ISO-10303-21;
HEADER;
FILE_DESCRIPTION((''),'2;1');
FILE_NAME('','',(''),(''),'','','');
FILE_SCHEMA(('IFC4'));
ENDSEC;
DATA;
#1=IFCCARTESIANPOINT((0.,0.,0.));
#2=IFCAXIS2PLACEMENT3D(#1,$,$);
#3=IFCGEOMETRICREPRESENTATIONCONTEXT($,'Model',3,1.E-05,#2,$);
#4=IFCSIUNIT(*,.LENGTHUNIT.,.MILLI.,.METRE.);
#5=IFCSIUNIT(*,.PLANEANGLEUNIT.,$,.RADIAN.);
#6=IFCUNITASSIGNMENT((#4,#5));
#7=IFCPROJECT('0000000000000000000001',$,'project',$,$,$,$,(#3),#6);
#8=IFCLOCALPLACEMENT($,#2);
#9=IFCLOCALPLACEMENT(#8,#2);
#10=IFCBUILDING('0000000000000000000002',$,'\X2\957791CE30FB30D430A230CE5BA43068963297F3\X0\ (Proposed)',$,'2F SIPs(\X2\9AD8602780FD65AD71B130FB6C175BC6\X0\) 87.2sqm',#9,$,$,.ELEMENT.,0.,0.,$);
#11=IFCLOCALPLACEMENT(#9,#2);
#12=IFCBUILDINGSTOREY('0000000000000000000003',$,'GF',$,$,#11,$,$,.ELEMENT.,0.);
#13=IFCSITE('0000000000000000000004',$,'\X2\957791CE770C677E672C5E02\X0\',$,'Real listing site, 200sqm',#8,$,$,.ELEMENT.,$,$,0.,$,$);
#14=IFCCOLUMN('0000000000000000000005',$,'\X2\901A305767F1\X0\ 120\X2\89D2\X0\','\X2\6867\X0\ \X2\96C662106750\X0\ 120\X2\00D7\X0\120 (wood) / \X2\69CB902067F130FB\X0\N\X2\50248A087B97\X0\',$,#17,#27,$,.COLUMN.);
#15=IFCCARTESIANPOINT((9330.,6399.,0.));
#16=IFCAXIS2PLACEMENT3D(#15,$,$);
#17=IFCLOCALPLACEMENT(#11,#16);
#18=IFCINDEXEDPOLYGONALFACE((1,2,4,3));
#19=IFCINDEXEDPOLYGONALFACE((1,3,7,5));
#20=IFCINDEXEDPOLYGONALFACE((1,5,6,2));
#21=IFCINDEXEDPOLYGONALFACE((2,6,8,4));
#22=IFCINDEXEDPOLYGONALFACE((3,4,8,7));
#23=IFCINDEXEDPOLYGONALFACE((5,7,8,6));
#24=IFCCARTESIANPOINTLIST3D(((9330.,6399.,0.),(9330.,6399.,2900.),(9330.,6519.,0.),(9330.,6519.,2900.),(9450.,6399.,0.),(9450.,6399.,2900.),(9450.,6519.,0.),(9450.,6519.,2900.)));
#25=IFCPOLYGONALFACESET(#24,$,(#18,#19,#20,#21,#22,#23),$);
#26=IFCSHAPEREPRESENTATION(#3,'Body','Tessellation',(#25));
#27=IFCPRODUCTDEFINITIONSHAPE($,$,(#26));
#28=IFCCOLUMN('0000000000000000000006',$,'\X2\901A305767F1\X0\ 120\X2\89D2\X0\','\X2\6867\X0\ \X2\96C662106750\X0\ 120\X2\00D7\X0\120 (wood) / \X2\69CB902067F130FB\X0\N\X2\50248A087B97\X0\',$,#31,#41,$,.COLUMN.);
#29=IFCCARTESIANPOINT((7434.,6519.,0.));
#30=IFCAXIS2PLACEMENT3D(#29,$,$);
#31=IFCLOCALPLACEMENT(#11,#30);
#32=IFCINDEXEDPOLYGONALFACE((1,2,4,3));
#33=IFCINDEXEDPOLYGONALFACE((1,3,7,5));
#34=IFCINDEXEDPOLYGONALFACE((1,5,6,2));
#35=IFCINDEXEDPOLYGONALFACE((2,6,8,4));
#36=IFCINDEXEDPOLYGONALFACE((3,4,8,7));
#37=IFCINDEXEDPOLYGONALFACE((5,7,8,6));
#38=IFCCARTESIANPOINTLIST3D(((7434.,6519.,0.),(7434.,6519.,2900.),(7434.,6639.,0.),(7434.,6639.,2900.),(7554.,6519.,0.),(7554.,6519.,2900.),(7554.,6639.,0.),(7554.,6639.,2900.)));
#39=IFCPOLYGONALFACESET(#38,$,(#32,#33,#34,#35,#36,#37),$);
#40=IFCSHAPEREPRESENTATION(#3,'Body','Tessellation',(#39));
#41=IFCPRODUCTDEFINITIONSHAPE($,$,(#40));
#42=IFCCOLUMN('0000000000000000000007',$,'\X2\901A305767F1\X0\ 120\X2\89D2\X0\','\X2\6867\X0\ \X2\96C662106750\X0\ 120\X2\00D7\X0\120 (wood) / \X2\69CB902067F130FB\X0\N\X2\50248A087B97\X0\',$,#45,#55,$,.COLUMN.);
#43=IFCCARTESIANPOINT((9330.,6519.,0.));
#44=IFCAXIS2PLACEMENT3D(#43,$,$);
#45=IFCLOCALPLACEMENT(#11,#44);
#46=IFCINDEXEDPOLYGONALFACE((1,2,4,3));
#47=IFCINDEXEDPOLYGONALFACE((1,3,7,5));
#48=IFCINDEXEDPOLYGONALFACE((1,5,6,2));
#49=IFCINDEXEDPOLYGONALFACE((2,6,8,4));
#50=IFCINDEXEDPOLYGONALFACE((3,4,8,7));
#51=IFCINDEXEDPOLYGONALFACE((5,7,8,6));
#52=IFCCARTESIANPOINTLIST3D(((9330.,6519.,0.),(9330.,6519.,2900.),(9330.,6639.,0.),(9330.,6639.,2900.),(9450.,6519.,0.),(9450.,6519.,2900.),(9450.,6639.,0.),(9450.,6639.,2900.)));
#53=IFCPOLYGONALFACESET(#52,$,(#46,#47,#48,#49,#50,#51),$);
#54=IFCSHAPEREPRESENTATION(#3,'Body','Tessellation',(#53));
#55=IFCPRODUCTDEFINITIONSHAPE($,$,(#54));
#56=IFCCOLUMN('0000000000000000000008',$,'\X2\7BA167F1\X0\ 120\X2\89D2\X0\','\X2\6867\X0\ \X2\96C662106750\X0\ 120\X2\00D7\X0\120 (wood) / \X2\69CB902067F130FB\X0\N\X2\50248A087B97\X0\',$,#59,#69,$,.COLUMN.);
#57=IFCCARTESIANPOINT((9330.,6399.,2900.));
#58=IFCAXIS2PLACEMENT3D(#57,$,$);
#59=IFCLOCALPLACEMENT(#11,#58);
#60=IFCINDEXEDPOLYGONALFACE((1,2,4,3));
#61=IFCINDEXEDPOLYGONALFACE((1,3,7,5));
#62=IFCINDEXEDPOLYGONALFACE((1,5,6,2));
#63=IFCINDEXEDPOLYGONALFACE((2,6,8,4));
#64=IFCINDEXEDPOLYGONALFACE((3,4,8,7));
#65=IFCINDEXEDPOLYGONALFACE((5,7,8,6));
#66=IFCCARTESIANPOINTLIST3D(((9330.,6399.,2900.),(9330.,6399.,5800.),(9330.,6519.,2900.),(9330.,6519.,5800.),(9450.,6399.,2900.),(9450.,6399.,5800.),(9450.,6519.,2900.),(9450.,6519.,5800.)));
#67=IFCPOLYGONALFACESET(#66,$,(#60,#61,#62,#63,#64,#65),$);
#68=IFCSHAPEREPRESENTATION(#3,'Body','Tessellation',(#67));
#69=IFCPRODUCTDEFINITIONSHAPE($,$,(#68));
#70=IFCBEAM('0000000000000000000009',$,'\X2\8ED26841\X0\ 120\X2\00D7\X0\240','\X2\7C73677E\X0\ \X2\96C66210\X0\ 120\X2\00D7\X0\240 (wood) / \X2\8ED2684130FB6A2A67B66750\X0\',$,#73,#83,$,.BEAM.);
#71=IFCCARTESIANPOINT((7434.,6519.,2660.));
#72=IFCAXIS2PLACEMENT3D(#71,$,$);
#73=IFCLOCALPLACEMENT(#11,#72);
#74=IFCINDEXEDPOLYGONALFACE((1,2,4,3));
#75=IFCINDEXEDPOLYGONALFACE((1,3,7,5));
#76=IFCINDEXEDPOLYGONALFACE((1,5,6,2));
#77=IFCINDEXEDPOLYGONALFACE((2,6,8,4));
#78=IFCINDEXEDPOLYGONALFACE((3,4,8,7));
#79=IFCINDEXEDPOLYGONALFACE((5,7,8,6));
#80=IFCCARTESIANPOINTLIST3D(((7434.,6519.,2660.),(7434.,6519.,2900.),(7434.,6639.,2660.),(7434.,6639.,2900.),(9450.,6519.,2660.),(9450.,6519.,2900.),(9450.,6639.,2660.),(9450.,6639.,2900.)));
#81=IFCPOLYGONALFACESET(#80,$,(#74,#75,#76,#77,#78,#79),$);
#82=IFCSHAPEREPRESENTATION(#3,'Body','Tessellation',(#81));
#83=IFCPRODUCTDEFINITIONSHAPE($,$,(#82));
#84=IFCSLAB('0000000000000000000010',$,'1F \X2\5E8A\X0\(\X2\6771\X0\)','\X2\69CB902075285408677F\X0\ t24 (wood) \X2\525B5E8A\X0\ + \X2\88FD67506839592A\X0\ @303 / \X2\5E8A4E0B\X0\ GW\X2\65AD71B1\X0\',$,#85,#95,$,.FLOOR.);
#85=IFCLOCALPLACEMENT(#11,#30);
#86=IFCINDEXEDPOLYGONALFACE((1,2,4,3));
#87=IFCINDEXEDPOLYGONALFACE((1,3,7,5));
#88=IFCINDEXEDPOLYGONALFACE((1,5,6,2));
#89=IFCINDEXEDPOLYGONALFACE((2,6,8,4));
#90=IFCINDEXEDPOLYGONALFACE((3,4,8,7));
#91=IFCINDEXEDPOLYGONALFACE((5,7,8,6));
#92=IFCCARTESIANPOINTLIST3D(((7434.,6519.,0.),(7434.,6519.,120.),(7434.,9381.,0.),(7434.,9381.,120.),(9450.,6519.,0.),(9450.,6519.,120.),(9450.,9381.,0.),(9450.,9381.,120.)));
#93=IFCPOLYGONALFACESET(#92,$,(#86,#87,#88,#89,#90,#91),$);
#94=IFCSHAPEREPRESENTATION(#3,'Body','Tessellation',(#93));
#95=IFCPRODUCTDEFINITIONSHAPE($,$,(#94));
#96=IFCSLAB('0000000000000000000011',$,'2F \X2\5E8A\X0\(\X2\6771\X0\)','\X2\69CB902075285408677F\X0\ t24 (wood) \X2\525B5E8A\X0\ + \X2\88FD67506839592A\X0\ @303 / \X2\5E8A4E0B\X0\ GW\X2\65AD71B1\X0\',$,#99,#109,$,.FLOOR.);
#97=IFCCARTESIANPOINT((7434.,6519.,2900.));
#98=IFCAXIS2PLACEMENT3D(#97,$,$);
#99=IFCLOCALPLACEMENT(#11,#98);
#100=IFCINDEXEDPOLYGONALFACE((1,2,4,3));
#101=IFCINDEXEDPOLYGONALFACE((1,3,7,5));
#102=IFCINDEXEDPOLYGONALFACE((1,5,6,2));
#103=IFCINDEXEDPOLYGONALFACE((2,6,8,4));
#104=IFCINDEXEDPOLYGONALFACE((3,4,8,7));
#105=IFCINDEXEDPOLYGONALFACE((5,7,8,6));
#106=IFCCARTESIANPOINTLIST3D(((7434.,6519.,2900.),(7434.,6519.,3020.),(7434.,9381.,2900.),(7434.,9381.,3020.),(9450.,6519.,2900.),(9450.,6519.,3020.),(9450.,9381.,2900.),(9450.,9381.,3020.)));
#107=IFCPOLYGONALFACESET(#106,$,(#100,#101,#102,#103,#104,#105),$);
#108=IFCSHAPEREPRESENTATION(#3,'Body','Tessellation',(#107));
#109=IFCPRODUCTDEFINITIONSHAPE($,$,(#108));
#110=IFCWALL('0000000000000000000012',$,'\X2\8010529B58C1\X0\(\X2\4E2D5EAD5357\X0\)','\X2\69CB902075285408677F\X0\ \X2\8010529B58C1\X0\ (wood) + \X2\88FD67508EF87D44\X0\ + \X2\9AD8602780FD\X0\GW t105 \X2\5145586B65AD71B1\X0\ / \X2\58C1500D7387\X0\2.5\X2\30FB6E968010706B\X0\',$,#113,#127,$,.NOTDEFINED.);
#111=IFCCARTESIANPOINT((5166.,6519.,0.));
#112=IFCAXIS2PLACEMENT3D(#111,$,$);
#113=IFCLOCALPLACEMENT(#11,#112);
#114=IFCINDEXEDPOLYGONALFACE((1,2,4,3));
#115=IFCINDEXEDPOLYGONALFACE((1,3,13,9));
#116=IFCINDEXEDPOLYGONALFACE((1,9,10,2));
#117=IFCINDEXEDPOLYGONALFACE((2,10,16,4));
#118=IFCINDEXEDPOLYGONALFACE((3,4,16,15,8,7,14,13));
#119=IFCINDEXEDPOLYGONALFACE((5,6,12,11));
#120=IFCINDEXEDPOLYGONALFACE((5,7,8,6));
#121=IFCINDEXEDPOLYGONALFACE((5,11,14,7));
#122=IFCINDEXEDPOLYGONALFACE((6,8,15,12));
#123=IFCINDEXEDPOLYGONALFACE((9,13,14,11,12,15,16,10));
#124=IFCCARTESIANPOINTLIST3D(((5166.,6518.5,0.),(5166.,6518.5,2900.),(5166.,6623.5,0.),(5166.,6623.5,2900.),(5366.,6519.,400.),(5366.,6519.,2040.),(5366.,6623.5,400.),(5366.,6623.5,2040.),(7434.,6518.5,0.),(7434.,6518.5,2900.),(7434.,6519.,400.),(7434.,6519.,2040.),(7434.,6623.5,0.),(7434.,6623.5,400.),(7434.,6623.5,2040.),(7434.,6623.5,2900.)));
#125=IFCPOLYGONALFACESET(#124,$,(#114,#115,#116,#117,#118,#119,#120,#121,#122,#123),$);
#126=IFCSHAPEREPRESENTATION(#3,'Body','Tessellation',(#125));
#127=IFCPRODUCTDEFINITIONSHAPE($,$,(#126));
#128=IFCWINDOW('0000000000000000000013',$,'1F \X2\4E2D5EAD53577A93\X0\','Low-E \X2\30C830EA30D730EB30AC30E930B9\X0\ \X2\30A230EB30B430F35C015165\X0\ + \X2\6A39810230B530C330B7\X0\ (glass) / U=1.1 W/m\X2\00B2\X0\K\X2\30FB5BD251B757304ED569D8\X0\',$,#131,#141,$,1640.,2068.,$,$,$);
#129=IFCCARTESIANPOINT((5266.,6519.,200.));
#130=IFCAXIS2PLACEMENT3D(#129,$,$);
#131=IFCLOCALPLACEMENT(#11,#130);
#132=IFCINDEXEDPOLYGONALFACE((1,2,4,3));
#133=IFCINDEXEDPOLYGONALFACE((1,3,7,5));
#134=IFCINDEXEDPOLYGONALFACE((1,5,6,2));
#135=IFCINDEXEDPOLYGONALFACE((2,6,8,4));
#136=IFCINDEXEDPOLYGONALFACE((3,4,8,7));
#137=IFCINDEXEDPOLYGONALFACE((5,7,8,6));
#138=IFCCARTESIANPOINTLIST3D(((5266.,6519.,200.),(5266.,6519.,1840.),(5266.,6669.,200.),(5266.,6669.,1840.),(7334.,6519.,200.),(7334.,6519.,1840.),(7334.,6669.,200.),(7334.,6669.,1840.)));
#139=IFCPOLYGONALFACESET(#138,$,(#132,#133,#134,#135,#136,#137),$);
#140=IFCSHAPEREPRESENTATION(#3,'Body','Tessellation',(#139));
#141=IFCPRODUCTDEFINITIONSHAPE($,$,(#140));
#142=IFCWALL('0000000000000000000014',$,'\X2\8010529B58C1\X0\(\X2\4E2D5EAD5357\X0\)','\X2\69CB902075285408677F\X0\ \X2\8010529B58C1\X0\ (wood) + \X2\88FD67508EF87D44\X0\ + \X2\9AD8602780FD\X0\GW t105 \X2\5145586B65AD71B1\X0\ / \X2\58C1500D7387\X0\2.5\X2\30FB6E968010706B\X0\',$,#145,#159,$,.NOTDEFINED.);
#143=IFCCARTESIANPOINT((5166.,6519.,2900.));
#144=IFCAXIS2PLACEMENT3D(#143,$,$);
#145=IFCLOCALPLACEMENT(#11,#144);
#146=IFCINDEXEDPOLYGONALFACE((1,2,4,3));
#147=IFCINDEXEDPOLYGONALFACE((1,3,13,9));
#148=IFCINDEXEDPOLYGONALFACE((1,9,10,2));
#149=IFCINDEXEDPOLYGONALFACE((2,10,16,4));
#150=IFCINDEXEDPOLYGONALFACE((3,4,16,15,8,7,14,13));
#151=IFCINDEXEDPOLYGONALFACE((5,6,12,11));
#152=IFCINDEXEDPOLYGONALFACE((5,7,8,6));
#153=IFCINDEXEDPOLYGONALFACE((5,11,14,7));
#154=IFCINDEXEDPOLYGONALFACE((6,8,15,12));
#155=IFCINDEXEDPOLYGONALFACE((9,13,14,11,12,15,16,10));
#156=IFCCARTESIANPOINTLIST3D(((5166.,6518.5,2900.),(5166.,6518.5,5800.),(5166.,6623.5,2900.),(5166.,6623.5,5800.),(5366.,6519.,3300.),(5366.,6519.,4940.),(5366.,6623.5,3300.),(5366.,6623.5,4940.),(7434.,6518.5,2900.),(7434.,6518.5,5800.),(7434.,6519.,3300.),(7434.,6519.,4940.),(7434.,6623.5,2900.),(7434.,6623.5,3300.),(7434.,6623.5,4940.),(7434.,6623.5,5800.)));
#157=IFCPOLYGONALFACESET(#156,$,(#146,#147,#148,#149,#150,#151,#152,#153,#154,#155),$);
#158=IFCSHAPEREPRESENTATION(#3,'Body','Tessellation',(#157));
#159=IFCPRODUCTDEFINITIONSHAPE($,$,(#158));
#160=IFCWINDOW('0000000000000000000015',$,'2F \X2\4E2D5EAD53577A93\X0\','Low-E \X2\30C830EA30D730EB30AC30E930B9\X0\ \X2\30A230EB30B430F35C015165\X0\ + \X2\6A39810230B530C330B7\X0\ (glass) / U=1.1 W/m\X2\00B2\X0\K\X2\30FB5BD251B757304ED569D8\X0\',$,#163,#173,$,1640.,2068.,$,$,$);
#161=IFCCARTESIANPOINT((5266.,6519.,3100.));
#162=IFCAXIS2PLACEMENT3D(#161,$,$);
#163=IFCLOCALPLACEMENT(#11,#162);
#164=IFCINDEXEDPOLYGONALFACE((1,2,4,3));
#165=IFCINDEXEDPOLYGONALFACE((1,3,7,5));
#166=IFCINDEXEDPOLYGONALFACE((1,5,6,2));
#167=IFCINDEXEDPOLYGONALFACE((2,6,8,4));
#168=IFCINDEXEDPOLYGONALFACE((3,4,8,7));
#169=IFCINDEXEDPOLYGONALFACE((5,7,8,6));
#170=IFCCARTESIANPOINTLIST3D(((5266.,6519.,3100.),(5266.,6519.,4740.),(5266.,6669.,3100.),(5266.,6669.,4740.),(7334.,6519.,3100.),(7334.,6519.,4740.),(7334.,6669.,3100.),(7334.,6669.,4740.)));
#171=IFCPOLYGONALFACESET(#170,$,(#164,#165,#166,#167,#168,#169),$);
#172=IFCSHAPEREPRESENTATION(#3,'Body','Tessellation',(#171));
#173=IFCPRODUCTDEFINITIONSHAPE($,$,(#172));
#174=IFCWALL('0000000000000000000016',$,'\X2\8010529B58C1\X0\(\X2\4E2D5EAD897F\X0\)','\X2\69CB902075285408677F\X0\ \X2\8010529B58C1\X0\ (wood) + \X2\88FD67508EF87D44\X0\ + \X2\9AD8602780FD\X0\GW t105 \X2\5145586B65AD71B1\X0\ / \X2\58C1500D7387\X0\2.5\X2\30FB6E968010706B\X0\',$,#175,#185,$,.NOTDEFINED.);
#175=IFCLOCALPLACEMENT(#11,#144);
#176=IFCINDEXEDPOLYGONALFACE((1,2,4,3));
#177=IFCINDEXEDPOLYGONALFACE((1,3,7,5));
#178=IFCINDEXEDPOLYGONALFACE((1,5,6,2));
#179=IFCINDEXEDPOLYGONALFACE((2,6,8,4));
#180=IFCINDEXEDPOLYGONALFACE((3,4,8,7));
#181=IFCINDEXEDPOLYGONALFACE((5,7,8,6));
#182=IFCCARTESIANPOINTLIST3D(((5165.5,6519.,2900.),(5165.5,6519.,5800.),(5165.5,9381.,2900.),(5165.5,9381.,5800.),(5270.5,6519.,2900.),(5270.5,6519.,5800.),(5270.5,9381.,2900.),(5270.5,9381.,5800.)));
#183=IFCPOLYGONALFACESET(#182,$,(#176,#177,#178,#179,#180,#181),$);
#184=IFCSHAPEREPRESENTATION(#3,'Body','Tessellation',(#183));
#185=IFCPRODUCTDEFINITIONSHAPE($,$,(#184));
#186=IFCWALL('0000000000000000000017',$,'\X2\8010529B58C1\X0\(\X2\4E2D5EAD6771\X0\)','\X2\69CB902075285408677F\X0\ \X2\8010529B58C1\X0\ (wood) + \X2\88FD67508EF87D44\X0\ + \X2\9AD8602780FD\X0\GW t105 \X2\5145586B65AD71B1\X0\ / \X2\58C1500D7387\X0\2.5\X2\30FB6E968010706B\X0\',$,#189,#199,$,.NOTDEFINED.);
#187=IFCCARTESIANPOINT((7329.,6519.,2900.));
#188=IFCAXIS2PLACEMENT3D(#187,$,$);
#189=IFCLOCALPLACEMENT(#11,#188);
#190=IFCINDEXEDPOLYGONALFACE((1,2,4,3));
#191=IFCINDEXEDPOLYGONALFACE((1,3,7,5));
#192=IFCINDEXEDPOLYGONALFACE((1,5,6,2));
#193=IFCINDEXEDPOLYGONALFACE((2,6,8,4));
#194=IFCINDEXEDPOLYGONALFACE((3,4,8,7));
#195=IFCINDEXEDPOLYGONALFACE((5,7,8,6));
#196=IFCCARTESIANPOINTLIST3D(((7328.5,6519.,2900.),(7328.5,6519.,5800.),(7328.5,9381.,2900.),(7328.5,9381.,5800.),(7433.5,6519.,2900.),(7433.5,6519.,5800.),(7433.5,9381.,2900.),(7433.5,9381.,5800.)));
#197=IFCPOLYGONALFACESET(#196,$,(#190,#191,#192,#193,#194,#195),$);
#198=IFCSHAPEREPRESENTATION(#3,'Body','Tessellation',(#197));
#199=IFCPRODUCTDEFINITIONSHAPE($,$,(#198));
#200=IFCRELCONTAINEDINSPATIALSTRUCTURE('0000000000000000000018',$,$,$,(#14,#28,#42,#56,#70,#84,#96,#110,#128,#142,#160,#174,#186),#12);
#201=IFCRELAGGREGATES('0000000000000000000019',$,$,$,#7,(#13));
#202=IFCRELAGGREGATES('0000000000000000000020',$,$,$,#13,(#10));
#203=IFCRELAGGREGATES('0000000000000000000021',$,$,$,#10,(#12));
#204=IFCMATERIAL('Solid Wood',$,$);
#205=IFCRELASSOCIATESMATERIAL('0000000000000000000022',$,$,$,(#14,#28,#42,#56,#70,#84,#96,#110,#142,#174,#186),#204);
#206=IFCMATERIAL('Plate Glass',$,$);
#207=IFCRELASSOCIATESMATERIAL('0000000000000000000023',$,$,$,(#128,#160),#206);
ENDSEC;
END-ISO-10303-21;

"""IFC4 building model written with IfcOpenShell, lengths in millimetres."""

from ifc_helpers import new_model, si_unit, frame, frame_2d, origin, place, context, project, spatial, rectangle, extrude, material, element, fill, save


model = new_model("IFC4")

# Units and contexts
model_context = context("Model", 3, precision=1e-05, world=origin())
ifc_project = project(units=[si_unit("LENGTHUNIT", "METRE", prefix="MILLI"), si_unit("PLANEANGLEUNIT", "RADIAN")], contexts=[model_context])

# Site, building, storey
site_placement = place(None, origin())
site = spatial("IfcSite", under=ifc_project, at=site_placement, Name="長野県松本市", ObjectType="Real listing site, 200sqm", CompositionType="ELEMENT", RefElevation=0.0)
building_placement = place(site_placement, origin())
building = spatial("IfcBuilding", under=site, at=building_placement, Name="長野・ピアノ室と防音 (Proposed)", ObjectType="2F SIPs(高性能断熱・気密) 87.2sqm", CompositionType="ELEMENT", ElevationOfRefHeight=0.0, ElevationOfTerrain=0.0)
storey_placement = place(building_placement, origin())
storey = spatial("IfcBuildingStorey", under=building, at=storey_placement, Name="GF", CompositionType="ELEMENT", Elevation=0.0)

# Columns
ifc_material_1 = material(Name="Solid Wood")
column_1_placement = place(storey_placement, frame((9330.0, 6399.0, 0.0)))
element("IfcColumn", 1, at=column_1_placement, inside=storey, material=ifc_material_1, Name="通し柱 120角", Description="桧 集成材 120×120 (wood) / 構造柱・N値計算", PredefinedType="COLUMN", context=model_context, shape_type="SweptSolid", body=[
    extrude(rectangle(XDim=120.0, YDim=120.0, at=frame_2d((60.0, 60.0))), frame((9330.0, 6399.0, 0.0)), (0.0, 0.0, 1.0), 2900.0),
])
column_2_placement = place(storey_placement, frame((7434.0, 6519.0, 0.0)))
element("IfcColumn", 2, at=column_2_placement, inside=storey, material=ifc_material_1, Name="通し柱 120角", Description="桧 集成材 120×120 (wood) / 構造柱・N値計算", PredefinedType="COLUMN", context=model_context, shape_type="SweptSolid", body=[
    extrude(rectangle(XDim=120.0, YDim=120.0, at=frame_2d((60.0, 60.0))), frame((7434.0, 6519.0, 0.0)), (0.0, 0.0, 1.0), 2900.0),
])
column_3_placement = place(storey_placement, frame((9330.0, 6519.0, 0.0)))
element("IfcColumn", 3, at=column_3_placement, inside=storey, material=ifc_material_1, Name="通し柱 120角", Description="桧 集成材 120×120 (wood) / 構造柱・N値計算", PredefinedType="COLUMN", context=model_context, shape_type="SweptSolid", body=[
    extrude(rectangle(XDim=120.0, YDim=120.0, at=frame_2d((60.0, 60.0))), frame((9330.0, 6519.0, 0.0)), (0.0, 0.0, 1.0), 2900.0),
])
column_4_placement = place(storey_placement, frame((9330.0, 6399.0, 2900.0)))
element("IfcColumn", 4, at=column_4_placement, inside=storey, material=ifc_material_1, Name="管柱 120角", Description="桧 集成材 120×120 (wood) / 構造柱・N値計算", PredefinedType="COLUMN", context=model_context, shape_type="SweptSolid", body=[
    extrude(rectangle(XDim=120.0, YDim=120.0, at=frame_2d((60.0, 60.0))), frame((9330.0, 6399.0, 2900.0)), (0.0, 0.0, 1.0), 2900.0),
])

# Beam
beam_1_placement = place(storey_placement, frame((7434.0, 6519.0, 2660.0)))
element("IfcBeam", 5, at=beam_1_placement, inside=storey, material=ifc_material_1, Name="軒桁 120×240", Description="米松 集成 120×240 (wood) / 軒桁・横架材", PredefinedType="BEAM", context=model_context, shape_type="SweptSolid", body=[
    extrude(rectangle(XDim=2016.0, YDim=120.0, at=frame_2d((1008.0, 60.0))), frame((7434.0, 6519.0, 2660.0)), (0.0, 0.0, 1.0), 240.0),
])

# Slabs
slab_1_placement = place(storey_placement, frame((7434.0, 6519.0, 0.0)))
element("IfcSlab", 6, at=slab_1_placement, inside=storey, material=ifc_material_1, Name="1F 床(東)", Description="構造用合板 t24 (wood) 剛床 + 製材根太 @303 / 床下 GW断熱", PredefinedType="FLOOR", context=model_context, shape_type="SweptSolid", body=[
    extrude(rectangle(XDim=2016.0, YDim=2862.0, at=frame_2d((1008.0, 1431.0))), frame((7434.0, 6519.0, 0.0)), (0.0, 0.0, 1.0), 120.0),
])
slab_2_placement = place(storey_placement, frame((7434.0, 6519.0, 2900.0)))
element("IfcSlab", 7, at=slab_2_placement, inside=storey, material=ifc_material_1, Name="2F 床(東)", Description="構造用合板 t24 (wood) 剛床 + 製材根太 @303 / 床下 GW断熱", PredefinedType="FLOOR", context=model_context, shape_type="SweptSolid", body=[
    extrude(rectangle(XDim=2016.0, YDim=2862.0, at=frame_2d((1008.0, 1431.0))), frame((7434.0, 6519.0, 2900.0)), (0.0, 0.0, 1.0), 120.0),
])

# Wall, opening, window
wall_1_placement = place(storey_placement, frame((5166.0, 6519.0, 0.0)))
wall_1 = element("IfcWall", 8, at=wall_1_placement, inside=storey, material=ifc_material_1, Name="耐力壁(中庭南)", Description="構造用合板 耐力壁 (wood) + 製材軸組 + 高性能GW t105 充填断熱 / 壁倍率2.5・準耐火", PredefinedType="NOTDEFINED", context=model_context, shape_type="SweptSolid", body=[
    extrude(rectangle(XDim=2268.0, YDim=105.0, at=frame_2d((1134.0, 52.0))), frame((5166.0, 6519.0, 0.0)), (0.0, 0.0, 1.0), 2900.0),
])
opening_1_placement = place(storey_placement, frame((5266.0, 6519.0, 200.0)))
opening_1 = element("IfcOpeningElement", 9, at=opening_1_placement, cuts=wall_1, PredefinedType="NOTDEFINED", context=model_context, shape_type="SweptSolid", body=[
    extrude(rectangle(XDim=2068.0, YDim=150.0, at=frame_2d((1034.0, 75.0))), frame((5266.0, 6519.0, 200.0)), (0.0, 0.0, 1.0), 1640.0),
])
ifc_material_2 = material(Name="Plate Glass")
window_1_placement = place(storey_placement, frame((5266.0, 6519.0, 200.0)))
window_1 = element("IfcWindow", 10, at=window_1_placement, inside=storey, material=ifc_material_2, Name="1F 中庭南窓", Description="Low-E トリプルガラス アルゴン封入 + 樹脂サッシ (glass) / U=1.1 W/m²K・寒冷地仕様", OverallHeight=1640.0, OverallWidth=2068.0, context=model_context, shape_type="SweptSolid", body=[
    extrude(rectangle(XDim=2068.0, YDim=150.0, at=frame_2d((1034.0, 75.0))), frame((5266.0, 6519.0, 200.0)), (0.0, 0.0, 1.0), 1640.0),
])
fill(opening_1, window_1)

# Wall, opening, window
wall_2_placement = place(storey_placement, frame((5166.0, 6519.0, 2900.0)))
wall_2 = element("IfcWall", 11, at=wall_2_placement, inside=storey, material=ifc_material_1, Name="耐力壁(中庭南)", Description="構造用合板 耐力壁 (wood) + 製材軸組 + 高性能GW t105 充填断熱 / 壁倍率2.5・準耐火", PredefinedType="NOTDEFINED", context=model_context, shape_type="SweptSolid", body=[
    extrude(rectangle(XDim=2268.0, YDim=105.0, at=frame_2d((1134.0, 52.0))), frame((5166.0, 6519.0, 2900.0)), (0.0, 0.0, 1.0), 2900.0),
])
opening_2_placement = place(storey_placement, frame((5266.0, 6519.0, 3100.0)))
opening_2 = element("IfcOpeningElement", 12, at=opening_2_placement, cuts=wall_2, PredefinedType="NOTDEFINED", context=model_context, shape_type="SweptSolid", body=[
    extrude(rectangle(XDim=2068.0, YDim=150.0, at=frame_2d((1034.0, 75.0))), frame((5266.0, 6519.0, 3100.0)), (0.0, 0.0, 1.0), 1640.0),
])
window_2_placement = place(storey_placement, frame((5266.0, 6519.0, 3100.0)))
window_2 = element("IfcWindow", 13, at=window_2_placement, inside=storey, material=ifc_material_2, Name="2F 中庭南窓", Description="Low-E トリプルガラス アルゴン封入 + 樹脂サッシ (glass) / U=1.1 W/m²K・寒冷地仕様", OverallHeight=1640.0, OverallWidth=2068.0, context=model_context, shape_type="SweptSolid", body=[
    extrude(rectangle(XDim=2068.0, YDim=150.0, at=frame_2d((1034.0, 75.0))), frame((5266.0, 6519.0, 3100.0)), (0.0, 0.0, 1.0), 1640.0),
])
fill(opening_2, window_2)

# Walls
wall_3_placement = place(storey_placement, frame((5166.0, 6519.0, 2900.0)))
element("IfcWall", 14, at=wall_3_placement, inside=storey, material=ifc_material_1, Name="耐力壁(中庭西)", Description="構造用合板 耐力壁 (wood) + 製材軸組 + 高性能GW t105 充填断熱 / 壁倍率2.5・準耐火", PredefinedType="NOTDEFINED", context=model_context, shape_type="SweptSolid", body=[
    extrude(rectangle(XDim=105.0, YDim=2862.0, at=frame_2d((52.0, 1431.0))), frame((5166.0, 6519.0, 2900.0)), (0.0, 0.0, 1.0), 2900.0),
])
wall_4_placement = place(storey_placement, frame((7329.0, 6519.0, 2900.0)))
element("IfcWall", 15, at=wall_4_placement, inside=storey, material=ifc_material_1, Name="耐力壁(中庭東)", Description="構造用合板 耐力壁 (wood) + 製材軸組 + 高性能GW t105 充填断熱 / 壁倍率2.5・準耐火", PredefinedType="NOTDEFINED", context=model_context, shape_type="SweptSolid", body=[
    extrude(rectangle(XDim=105.0, YDim=2862.0, at=frame_2d((52.0, 1431.0))), frame((7329.0, 6519.0, 2900.0)), (0.0, 0.0, 1.0), 2900.0),
])

save(model, "model.ifc")
